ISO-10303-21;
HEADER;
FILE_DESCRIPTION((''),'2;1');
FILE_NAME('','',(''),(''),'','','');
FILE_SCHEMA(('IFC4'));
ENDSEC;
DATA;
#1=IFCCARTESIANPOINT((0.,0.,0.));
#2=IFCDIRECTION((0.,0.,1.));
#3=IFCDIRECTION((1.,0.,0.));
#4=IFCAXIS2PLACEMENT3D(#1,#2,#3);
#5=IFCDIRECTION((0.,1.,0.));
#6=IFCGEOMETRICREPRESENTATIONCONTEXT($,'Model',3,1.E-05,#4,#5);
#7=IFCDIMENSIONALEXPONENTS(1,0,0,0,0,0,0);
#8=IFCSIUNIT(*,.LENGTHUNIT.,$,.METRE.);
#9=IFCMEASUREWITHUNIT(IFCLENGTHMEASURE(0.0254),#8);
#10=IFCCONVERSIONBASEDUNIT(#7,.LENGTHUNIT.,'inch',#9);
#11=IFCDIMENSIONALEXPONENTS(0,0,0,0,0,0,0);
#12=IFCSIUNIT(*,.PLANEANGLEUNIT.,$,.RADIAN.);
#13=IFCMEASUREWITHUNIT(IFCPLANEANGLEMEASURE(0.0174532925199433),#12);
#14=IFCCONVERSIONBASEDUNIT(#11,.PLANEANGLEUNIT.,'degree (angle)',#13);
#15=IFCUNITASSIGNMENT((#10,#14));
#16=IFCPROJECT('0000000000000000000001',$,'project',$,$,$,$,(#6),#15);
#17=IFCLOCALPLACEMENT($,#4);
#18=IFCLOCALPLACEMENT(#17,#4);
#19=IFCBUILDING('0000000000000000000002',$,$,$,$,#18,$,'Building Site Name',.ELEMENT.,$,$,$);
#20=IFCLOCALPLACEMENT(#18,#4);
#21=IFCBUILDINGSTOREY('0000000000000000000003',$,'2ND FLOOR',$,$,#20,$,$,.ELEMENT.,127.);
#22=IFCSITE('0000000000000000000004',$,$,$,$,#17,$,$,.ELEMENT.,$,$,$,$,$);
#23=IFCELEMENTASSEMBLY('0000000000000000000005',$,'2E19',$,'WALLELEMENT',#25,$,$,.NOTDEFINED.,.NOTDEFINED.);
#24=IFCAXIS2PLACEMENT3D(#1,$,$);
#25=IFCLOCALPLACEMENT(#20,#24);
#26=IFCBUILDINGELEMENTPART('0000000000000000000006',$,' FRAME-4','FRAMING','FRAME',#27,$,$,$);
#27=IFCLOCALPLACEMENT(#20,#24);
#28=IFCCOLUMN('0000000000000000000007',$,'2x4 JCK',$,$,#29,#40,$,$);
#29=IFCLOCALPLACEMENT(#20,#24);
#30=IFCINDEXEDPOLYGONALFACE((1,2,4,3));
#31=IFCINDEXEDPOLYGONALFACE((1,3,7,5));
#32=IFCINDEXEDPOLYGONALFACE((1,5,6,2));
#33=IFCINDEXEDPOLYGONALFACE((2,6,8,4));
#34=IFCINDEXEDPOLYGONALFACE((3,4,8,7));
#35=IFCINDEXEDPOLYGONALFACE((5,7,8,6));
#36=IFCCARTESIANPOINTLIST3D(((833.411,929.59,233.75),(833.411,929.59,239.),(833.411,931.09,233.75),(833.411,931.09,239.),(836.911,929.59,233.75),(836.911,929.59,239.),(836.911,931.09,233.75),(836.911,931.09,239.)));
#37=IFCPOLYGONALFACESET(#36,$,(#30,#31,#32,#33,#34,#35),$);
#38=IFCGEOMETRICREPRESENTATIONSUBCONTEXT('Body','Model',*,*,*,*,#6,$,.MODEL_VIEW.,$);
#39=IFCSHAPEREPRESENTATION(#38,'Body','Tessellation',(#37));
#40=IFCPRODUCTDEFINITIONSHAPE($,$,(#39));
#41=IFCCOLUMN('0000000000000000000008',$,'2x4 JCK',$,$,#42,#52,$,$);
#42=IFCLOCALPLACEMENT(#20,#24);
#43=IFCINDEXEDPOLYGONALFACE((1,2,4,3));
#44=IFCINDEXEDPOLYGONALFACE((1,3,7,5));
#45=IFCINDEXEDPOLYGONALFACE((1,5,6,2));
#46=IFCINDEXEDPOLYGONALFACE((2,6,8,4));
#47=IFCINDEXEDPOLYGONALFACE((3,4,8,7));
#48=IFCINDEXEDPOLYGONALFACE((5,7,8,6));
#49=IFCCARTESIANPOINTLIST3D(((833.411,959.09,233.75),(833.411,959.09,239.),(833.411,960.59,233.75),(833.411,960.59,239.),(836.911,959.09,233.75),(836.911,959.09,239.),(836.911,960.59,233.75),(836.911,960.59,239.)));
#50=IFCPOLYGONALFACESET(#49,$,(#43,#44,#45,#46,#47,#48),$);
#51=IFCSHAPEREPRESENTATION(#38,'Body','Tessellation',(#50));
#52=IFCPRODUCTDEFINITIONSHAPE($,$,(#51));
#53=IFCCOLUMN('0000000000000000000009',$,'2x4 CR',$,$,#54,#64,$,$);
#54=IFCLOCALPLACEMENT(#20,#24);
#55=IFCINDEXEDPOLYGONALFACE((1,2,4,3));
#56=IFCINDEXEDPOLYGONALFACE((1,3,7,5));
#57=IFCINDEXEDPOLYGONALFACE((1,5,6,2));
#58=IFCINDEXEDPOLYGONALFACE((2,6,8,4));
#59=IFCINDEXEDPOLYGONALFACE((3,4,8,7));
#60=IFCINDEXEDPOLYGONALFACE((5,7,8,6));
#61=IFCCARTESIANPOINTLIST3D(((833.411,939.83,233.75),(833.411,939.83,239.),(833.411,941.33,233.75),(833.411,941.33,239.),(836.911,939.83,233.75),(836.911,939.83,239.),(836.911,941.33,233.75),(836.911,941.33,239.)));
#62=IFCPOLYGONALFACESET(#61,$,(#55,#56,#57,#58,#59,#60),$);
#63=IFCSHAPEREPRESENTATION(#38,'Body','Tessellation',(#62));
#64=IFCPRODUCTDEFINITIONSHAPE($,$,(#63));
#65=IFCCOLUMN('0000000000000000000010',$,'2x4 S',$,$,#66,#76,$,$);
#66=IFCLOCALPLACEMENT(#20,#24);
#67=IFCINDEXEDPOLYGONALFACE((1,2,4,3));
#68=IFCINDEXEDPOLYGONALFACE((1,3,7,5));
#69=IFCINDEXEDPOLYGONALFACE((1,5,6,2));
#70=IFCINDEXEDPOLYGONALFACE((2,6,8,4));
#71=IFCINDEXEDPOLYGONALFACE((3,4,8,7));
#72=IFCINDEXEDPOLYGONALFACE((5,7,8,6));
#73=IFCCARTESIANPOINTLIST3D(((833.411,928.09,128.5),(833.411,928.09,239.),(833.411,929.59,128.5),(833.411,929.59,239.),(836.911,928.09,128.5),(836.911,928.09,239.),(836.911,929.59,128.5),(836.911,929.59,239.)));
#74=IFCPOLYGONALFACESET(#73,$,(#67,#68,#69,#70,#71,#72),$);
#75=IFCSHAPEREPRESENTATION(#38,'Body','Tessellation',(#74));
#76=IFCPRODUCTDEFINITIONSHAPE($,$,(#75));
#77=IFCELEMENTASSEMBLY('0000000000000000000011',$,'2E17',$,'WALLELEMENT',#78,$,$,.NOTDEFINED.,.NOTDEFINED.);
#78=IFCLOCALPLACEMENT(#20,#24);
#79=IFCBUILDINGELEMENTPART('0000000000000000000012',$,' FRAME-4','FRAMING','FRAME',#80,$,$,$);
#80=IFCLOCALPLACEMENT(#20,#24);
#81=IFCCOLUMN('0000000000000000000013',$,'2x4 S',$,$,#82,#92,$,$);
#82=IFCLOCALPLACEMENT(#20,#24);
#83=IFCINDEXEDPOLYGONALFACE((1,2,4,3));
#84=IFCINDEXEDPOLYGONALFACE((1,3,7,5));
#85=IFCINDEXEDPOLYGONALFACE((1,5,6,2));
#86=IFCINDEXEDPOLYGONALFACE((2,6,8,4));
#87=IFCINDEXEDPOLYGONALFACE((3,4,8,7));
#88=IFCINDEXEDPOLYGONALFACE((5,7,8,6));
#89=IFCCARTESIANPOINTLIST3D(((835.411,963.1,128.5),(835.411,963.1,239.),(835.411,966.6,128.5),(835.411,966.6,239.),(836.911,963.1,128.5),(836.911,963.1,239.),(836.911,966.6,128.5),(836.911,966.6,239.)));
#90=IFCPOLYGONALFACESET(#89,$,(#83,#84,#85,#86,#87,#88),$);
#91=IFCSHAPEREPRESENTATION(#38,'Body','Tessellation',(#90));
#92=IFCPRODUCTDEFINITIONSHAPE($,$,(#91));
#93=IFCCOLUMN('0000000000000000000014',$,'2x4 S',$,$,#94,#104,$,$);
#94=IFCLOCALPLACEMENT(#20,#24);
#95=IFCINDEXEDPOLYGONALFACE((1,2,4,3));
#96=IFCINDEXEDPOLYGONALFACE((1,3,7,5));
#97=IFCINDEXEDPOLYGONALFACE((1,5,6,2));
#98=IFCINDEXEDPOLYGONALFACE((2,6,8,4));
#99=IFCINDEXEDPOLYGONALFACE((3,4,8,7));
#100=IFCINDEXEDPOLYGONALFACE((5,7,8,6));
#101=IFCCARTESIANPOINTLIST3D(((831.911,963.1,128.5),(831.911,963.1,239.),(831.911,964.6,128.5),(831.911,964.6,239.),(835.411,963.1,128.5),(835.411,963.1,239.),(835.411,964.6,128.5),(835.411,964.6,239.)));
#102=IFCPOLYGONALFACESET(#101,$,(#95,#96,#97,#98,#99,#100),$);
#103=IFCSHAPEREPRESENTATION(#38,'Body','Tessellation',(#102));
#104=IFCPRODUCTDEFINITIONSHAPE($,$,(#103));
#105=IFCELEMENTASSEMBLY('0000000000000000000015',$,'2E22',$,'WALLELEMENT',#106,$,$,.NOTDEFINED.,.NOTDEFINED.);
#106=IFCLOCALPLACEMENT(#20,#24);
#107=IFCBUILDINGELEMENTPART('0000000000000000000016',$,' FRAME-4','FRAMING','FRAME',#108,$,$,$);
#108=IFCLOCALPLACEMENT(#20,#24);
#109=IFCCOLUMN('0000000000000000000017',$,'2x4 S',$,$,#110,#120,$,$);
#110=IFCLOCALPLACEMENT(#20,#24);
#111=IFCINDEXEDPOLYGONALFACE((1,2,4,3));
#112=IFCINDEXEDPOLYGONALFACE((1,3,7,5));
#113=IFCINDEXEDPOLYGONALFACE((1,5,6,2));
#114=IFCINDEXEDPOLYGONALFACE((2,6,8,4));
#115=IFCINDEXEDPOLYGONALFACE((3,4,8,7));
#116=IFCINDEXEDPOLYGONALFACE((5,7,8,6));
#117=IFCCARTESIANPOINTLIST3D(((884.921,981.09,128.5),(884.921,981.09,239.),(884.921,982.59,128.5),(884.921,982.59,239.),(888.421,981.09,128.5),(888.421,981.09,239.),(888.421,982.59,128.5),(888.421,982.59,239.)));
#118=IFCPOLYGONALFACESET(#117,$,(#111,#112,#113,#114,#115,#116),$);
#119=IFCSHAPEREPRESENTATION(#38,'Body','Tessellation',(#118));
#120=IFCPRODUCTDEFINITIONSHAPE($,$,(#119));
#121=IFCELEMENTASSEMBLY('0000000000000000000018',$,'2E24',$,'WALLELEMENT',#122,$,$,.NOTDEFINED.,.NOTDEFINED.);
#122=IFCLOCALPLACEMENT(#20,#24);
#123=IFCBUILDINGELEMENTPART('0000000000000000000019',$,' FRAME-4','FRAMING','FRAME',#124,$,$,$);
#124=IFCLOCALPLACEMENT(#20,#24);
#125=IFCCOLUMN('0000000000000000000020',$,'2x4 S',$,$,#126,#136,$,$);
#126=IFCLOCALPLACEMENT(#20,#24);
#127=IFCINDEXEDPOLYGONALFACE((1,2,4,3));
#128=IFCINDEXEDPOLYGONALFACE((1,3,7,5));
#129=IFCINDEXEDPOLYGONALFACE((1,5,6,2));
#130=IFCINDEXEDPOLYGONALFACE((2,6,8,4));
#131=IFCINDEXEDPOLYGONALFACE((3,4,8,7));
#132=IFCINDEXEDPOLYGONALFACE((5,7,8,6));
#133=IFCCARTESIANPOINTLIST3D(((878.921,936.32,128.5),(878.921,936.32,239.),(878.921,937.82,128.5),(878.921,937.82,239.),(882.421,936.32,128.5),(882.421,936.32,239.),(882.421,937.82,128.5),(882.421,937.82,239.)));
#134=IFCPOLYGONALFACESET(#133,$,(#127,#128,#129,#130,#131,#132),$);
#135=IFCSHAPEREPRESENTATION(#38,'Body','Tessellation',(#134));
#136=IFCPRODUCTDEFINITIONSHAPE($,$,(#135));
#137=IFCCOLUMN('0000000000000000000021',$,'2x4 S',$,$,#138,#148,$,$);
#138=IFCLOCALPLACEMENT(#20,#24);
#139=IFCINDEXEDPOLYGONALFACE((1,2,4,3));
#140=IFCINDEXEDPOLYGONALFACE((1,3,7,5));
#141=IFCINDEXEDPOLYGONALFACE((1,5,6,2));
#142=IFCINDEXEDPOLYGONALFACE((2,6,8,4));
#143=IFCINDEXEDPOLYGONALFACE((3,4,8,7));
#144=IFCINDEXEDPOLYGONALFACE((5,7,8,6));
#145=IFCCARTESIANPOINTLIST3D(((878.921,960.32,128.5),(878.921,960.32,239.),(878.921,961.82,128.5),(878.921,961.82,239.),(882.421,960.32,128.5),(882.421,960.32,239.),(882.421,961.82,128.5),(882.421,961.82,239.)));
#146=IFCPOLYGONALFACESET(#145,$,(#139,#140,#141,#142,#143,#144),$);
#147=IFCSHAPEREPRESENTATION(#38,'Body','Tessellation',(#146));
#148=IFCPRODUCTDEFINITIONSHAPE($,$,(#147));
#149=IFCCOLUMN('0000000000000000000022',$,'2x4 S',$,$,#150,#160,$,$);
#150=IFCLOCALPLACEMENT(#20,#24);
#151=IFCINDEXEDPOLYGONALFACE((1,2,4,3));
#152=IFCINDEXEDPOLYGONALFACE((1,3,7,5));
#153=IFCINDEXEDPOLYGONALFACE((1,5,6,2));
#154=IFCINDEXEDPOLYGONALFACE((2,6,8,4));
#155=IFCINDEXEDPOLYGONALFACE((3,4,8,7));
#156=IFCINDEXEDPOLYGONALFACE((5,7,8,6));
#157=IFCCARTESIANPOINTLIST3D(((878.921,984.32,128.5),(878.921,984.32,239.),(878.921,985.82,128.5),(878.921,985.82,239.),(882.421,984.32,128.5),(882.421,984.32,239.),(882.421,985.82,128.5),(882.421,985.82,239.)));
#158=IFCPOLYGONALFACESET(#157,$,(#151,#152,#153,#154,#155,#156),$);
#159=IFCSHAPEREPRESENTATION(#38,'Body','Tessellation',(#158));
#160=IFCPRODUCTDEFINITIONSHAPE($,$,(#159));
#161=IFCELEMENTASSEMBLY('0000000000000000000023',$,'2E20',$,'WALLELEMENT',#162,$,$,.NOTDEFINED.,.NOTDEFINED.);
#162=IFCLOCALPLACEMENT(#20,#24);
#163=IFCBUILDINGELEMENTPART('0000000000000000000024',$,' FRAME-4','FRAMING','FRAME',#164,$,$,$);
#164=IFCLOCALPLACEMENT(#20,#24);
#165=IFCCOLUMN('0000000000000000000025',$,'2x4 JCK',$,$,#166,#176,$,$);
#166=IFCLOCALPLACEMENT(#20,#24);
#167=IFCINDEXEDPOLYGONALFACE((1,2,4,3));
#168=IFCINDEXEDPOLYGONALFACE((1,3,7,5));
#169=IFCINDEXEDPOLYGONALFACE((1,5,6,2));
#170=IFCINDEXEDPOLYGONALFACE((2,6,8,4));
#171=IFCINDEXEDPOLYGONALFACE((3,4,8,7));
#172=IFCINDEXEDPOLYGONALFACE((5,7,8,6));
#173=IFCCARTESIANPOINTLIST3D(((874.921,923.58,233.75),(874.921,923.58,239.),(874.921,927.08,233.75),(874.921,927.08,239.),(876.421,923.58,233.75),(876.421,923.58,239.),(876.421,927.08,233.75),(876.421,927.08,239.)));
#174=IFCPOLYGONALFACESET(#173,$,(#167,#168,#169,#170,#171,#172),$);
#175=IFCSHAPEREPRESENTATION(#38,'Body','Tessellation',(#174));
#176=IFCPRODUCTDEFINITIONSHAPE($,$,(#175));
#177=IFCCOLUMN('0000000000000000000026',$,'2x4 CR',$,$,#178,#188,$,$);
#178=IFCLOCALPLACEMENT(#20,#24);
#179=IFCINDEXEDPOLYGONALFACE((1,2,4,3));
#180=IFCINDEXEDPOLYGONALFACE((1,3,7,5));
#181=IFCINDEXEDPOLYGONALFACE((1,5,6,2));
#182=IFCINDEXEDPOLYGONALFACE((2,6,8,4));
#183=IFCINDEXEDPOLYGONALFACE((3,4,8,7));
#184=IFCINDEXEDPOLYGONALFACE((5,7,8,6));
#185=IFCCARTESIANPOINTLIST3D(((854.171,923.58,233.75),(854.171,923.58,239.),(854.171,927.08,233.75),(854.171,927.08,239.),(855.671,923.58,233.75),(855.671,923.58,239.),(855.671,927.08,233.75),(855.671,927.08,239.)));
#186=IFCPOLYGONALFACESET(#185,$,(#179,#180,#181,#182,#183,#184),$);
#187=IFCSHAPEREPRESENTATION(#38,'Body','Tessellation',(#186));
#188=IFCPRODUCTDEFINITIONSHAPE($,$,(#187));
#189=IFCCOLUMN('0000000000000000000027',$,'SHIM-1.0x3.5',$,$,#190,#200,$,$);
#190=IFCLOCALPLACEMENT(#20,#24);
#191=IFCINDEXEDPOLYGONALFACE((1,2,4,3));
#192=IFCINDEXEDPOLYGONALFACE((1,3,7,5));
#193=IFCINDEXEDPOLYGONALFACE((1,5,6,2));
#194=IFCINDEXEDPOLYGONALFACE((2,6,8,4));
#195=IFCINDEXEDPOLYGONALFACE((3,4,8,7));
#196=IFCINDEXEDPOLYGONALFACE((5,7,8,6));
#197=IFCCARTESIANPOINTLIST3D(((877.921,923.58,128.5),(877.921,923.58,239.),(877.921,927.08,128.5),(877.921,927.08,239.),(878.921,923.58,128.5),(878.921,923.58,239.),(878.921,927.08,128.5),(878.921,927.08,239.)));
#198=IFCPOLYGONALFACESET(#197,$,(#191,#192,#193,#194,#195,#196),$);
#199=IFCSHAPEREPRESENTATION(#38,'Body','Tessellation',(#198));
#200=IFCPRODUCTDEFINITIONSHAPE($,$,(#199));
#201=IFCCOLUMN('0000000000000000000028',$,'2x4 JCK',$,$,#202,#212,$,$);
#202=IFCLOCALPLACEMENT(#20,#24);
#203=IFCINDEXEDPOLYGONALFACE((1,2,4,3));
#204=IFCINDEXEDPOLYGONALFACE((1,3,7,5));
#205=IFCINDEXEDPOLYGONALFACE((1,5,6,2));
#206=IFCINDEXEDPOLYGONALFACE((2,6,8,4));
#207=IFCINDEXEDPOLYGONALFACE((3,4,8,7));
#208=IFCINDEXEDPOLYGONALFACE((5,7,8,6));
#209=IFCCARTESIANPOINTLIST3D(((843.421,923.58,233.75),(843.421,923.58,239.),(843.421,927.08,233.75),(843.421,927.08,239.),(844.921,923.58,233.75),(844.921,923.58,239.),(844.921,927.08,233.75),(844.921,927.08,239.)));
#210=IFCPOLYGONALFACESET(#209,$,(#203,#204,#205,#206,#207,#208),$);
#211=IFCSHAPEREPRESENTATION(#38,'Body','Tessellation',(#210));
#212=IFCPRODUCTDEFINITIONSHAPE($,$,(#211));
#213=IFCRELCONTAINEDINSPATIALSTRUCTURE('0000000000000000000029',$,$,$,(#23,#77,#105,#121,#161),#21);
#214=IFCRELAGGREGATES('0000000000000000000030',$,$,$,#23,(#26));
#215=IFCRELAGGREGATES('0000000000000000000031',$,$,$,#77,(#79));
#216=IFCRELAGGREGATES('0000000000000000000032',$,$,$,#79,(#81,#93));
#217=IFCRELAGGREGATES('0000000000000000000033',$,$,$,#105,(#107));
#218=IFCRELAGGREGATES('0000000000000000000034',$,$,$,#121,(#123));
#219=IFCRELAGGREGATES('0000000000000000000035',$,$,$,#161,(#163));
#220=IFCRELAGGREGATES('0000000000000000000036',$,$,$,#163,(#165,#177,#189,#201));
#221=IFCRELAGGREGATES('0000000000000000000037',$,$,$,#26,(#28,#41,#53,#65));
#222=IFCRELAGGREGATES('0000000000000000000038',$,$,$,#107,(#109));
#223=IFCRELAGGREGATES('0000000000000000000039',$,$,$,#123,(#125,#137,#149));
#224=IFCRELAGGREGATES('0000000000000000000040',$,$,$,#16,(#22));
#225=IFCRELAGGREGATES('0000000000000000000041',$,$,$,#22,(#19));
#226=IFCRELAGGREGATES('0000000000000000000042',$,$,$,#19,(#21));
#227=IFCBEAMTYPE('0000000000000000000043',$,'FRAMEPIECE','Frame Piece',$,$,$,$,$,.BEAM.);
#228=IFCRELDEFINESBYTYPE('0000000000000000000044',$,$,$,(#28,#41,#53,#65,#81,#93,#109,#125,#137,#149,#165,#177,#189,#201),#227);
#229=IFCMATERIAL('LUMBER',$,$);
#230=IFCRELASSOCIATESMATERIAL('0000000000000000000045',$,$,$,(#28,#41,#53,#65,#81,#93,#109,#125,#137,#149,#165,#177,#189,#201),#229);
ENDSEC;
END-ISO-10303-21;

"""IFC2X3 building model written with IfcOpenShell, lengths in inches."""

from ifc_helpers import new_model, entity, si_unit, converted_unit, direction, frame, frame_2d, origin_with_axes, place, context, subcontext, project, spatial, rectangle, extrude, material, type_object, element, aggregate, save


model = new_model("IFC2X3")

# Units and contexts
model_context = context("Model", 3, precision=1e-05, world=origin_with_axes(), true_north=direction((0.0, 1.0, 0.0)))
body_context = subcontext(model_context, "Body", "Model", "MODEL_VIEW")
ifc_project = project(units=[converted_unit("LENGTHUNIT", "inch", entity("IfcLengthMeasure", 0.0254), si_unit("LENGTHUNIT", "METRE"), dimensions=[1, 0, 0, 0, 0, 0, 0]), converted_unit("PLANEANGLEUNIT", "degree (angle)", entity("IfcPlaneAngleMeasure", 0.0174532925199433), si_unit("PLANEANGLEUNIT", "RADIAN"), dimensions=[0, 0, 0, 0, 0, 0, 0])], contexts=[model_context])

# Site, building, storey
site_placement = place(None, origin_with_axes())
site = spatial("IfcSite", under=ifc_project, at=site_placement, CompositionType="ELEMENT")
building_placement = place(site_placement, origin_with_axes())
building = spatial("IfcBuilding", under=site, at=building_placement, LongName="Building Site Name", CompositionType="ELEMENT")
storey_placement = place(building_placement, origin_with_axes())
storey = spatial("IfcBuildingStorey", under=building, at=storey_placement, Name="2ND FLOOR", CompositionType="ELEMENT", Elevation=127.0)

# Element assemblies, building element parts, columns
assembly_1_placement = place(storey_placement, origin_with_axes())
assembly_1 = element("IfcElementAssembly", 1, at=assembly_1_placement, inside=storey, Name="2E19", ObjectType="WALLELEMENT", AssemblyPlace="NOTDEFINED", PredefinedType="NOTDEFINED")
building_element_part_1 = element("IfcBuildingElementPart", 2, Name=" FRAME-4", Description="FRAMING", ObjectType="FRAME")
aggregate(assembly_1, [building_element_part_1])
ifc_material = material(Name="LUMBER")
beam_type = type_object("IfcBeamType", Name="FRAMEPIECE", Description="Frame Piece", PredefinedType="BEAM")
column_1_placement = place(assembly_1_placement, frame((835.161, 930.34, 239.0), z_axis=(0.0, 0.0, -1.0), x_axis=(0.0, 1.0, 0.0)))
column_1 = element("IfcColumn", 3, at=column_1_placement, type_object=beam_type, material=ifc_material, Name="2x4 JCK", context=body_context, shape_type="SweptSolid", body=[
    extrude(rectangle(XDim=1.5, YDim=3.5, at=frame_2d((0.0, 0.0), x_axis=(-1.0, 0.0))), origin_with_axes(), (0.0, 0.0, 1.0), 5.25),
])
column_2_placement = place(assembly_1_placement, frame((835.161, 959.84, 233.75), z_axis=(0.0, 0.0, 1.0), x_axis=(0.0, -1.0, 0.0)))
column_2 = element("IfcColumn", 4, at=column_2_placement, type_object=beam_type, material=ifc_material, Name="2x4 JCK", context=body_context, shape_type="SweptSolid", body=[
    extrude(rectangle(XDim=1.5, YDim=3.5, at=frame_2d((0.0, 0.0), x_axis=(-1.0, 0.0))), origin_with_axes(), (0.0, 0.0, 1.0), 5.25),
])
column_3_placement = place(assembly_1_placement, frame((835.161, 940.58, 239.0), z_axis=(0.0, 0.0, -1.0), x_axis=(0.0, 1.0, 0.0)))
column_3 = element("IfcColumn", 5, at=column_3_placement, type_object=beam_type, material=ifc_material, Name="2x4 CR", context=body_context, shape_type="SweptSolid", body=[
    extrude(rectangle(XDim=1.5, YDim=3.5, at=frame_2d((0.0, 0.0), x_axis=(-1.0, 0.0))), origin_with_axes(), (0.0, 0.0, 1.0), 5.25),
])
column_4_placement = place(assembly_1_placement, frame((835.161, 928.84, 239.0), z_axis=(0.0, 0.0, -1.0), x_axis=(0.0, 1.0, 0.0)))
column_4 = element("IfcColumn", 6, at=column_4_placement, type_object=beam_type, material=ifc_material, Name="2x4 S", context=body_context, shape_type="SweptSolid", body=[
    extrude(rectangle(XDim=1.5, YDim=3.5, at=frame_2d((0.0, 0.0), x_axis=(-1.0, 0.0))), origin_with_axes(), (0.0, 0.0, 1.0), 110.5),
])
assembly_2_placement = place(storey_placement, origin_with_axes())
assembly_2 = element("IfcElementAssembly", 7, at=assembly_2_placement, inside=storey, Name="2E17", ObjectType="WALLELEMENT", AssemblyPlace="NOTDEFINED", PredefinedType="NOTDEFINED")
building_element_part_2 = element("IfcBuildingElementPart", 8, Name=" FRAME-4", Description="FRAMING", ObjectType="FRAME")
aggregate(assembly_2, [building_element_part_2])
column_5_placement = place(assembly_2_placement, frame((836.161, 964.85, 239.0), z_axis=(0.0, 0.0, -1.0), x_axis=(-1.0, 0.0, 0.0)))
column_5 = element("IfcColumn", 9, at=column_5_placement, type_object=beam_type, material=ifc_material, Name="2x4 S", context=body_context, shape_type="SweptSolid", body=[
    extrude(rectangle(XDim=1.5, YDim=3.5, at=frame_2d((0.0, 0.0), x_axis=(-1.0, 0.0))), origin_with_axes(), (0.0, 0.0, 1.0), 110.5),
])
column_6_placement = place(assembly_2_placement, frame((833.661, 963.85, 239.0), z_axis=(0.0, 0.0, -1.0), x_axis=(0.0, -1.0, 0.0)))
column_6 = element("IfcColumn", 10, at=column_6_placement, type_object=beam_type, material=ifc_material, Name="2x4 S", context=body_context, shape_type="SweptSolid", body=[
    extrude(rectangle(XDim=1.5, YDim=3.5, at=frame_2d((0.0, 0.0), x_axis=(-1.0, 0.0))), origin_with_axes(), (0.0, 0.0, 1.0), 110.5),
])
aggregate(building_element_part_2, [column_5, column_6])

# Element assembly, building element part, column
assembly_3_placement = place(storey_placement, origin_with_axes())
assembly_3 = element("IfcElementAssembly", 11, at=assembly_3_placement, inside=storey, Name="2E22", ObjectType="WALLELEMENT", AssemblyPlace="NOTDEFINED", PredefinedType="NOTDEFINED")
building_element_part_3 = element("IfcBuildingElementPart", 12, Name=" FRAME-4", Description="FRAMING", ObjectType="FRAME")
aggregate(assembly_3, [building_element_part_3])
column_7_placement = place(assembly_3_placement, frame((886.671, 981.84, 239.0), z_axis=(0.0, 0.0, -1.0), x_axis=(0.0, 1.0, 0.0)))
column_7 = element("IfcColumn", 13, at=column_7_placement, type_object=beam_type, material=ifc_material, Name="2x4 S", context=body_context, shape_type="SweptSolid", body=[
    extrude(rectangle(XDim=1.5, YDim=3.5, at=frame_2d((0.0, 0.0), x_axis=(-1.0, 0.0))), origin_with_axes(), (0.0, 0.0, 1.0), 110.5),
])

# Element assemblies, building element parts, columns
assembly_4_placement = place(storey_placement, origin_with_axes())
assembly_4 = element("IfcElementAssembly", 14, at=assembly_4_placement, inside=storey, Name="2E24", ObjectType="WALLELEMENT", AssemblyPlace="NOTDEFINED", PredefinedType="NOTDEFINED")
building_element_part_4 = element("IfcBuildingElementPart", 15, Name=" FRAME-4", Description="FRAMING", ObjectType="FRAME")
aggregate(assembly_4, [building_element_part_4])
column_8_placement = place(assembly_4_placement, frame((880.671, 937.07, 239.0), z_axis=(0.0, 0.0, -1.0), x_axis=(0.0, 1.0, 0.0)))
column_8 = element("IfcColumn", 16, at=column_8_placement, type_object=beam_type, material=ifc_material, Name="2x4 S", context=body_context, shape_type="SweptSolid", body=[
    extrude(rectangle(XDim=1.5, YDim=3.5, at=frame_2d((0.0, 0.0), x_axis=(-1.0, 0.0))), origin_with_axes(), (0.0, 0.0, 1.0), 110.5),
])
column_9_placement = place(assembly_4_placement, frame((880.671, 961.07, 239.0), z_axis=(0.0, 0.0, -1.0), x_axis=(0.0, 1.0, 0.0)))
column_9 = element("IfcColumn", 17, at=column_9_placement, type_object=beam_type, material=ifc_material, Name="2x4 S", context=body_context, shape_type="SweptSolid", body=[
    extrude(rectangle(XDim=1.5, YDim=3.5, at=frame_2d((0.0, 0.0), x_axis=(-1.0, 0.0))), origin_with_axes(), (0.0, 0.0, 1.0), 110.5),
])
column_10_placement = place(assembly_4_placement, frame((880.671, 985.07, 239.0), z_axis=(0.0, 0.0, -1.0), x_axis=(0.0, 1.0, 0.0)))
column_10 = element("IfcColumn", 18, at=column_10_placement, type_object=beam_type, material=ifc_material, Name="2x4 S", context=body_context, shape_type="SweptSolid", body=[
    extrude(rectangle(XDim=1.5, YDim=3.5, at=frame_2d((0.0, 0.0), x_axis=(-1.0, 0.0))), origin_with_axes(), (0.0, 0.0, 1.0), 110.5),
])
assembly_5_placement = place(storey_placement, origin_with_axes())
assembly_5 = element("IfcElementAssembly", 19, at=assembly_5_placement, inside=storey, Name="2E20", ObjectType="WALLELEMENT", AssemblyPlace="NOTDEFINED", PredefinedType="NOTDEFINED")
building_element_part_5 = element("IfcBuildingElementPart", 20, Name=" FRAME-4", Description="FRAMING", ObjectType="FRAME")
aggregate(assembly_5, [building_element_part_5])
column_11_placement = place(assembly_5_placement, frame((875.671, 925.33, 239.0), z_axis=(0.0, 0.0, -1.0), x_axis=(-1.0, 0.0, 0.0)))
column_11 = element("IfcColumn", 21, at=column_11_placement, type_object=beam_type, material=ifc_material, Name="2x4 JCK", context=body_context, shape_type="SweptSolid", body=[
    extrude(rectangle(XDim=1.5, YDim=3.5, at=frame_2d((0.0, 0.0), x_axis=(-1.0, 0.0))), origin_with_axes(), (0.0, 0.0, 1.0), 5.25),
])
column_12_placement = place(assembly_5_placement, frame((854.921, 925.33, 239.0), z_axis=(0.0, 0.0, -1.0), x_axis=(-1.0, 0.0, 0.0)))
column_12 = element("IfcColumn", 22, at=column_12_placement, type_object=beam_type, material=ifc_material, Name="2x4 CR", context=body_context, shape_type="SweptSolid", body=[
    extrude(rectangle(XDim=1.5, YDim=3.5, at=frame_2d((0.0, 0.0), x_axis=(-1.0, 0.0))), origin_with_axes(), (0.0, 0.0, 1.0), 5.25),
])
column_13_placement = place(assembly_5_placement, frame((878.421, 925.33, 239.0), z_axis=(0.0, 0.0, -1.0), x_axis=(-1.0, 0.0, 0.0)))
column_13 = element("IfcColumn", 23, at=column_13_placement, type_object=beam_type, material=ifc_material, Name="SHIM-1.0x3.5", context=body_context, shape_type="SweptSolid", body=[
    extrude(rectangle(XDim=1.0, YDim=3.5, at=frame_2d((0.0, 0.0), x_axis=(-1.0, 0.0))), origin_with_axes(), (0.0, 0.0, 1.0), 110.5),
])
column_14_placement = place(assembly_5_placement, frame((844.171, 925.33, 233.75), z_axis=(0.0, 0.0, 1.0), x_axis=(1.0, 0.0, 0.0)))
column_14 = element("IfcColumn", 24, at=column_14_placement, type_object=beam_type, material=ifc_material, Name="2x4 JCK", context=body_context, shape_type="SweptSolid", body=[
    extrude(rectangle(XDim=1.5, YDim=3.5, at=frame_2d((0.0, 0.0), x_axis=(-1.0, 0.0))), origin_with_axes(), (0.0, 0.0, 1.0), 5.25),
])
aggregate(building_element_part_5, [column_11, column_12, column_13, column_14])

aggregate(building_element_part_1, [column_1, column_2, column_3, column_4])
aggregate(building_element_part_3, [column_7])
aggregate(building_element_part_4, [column_8, column_9, column_10])

save(model, "model.ifc")
